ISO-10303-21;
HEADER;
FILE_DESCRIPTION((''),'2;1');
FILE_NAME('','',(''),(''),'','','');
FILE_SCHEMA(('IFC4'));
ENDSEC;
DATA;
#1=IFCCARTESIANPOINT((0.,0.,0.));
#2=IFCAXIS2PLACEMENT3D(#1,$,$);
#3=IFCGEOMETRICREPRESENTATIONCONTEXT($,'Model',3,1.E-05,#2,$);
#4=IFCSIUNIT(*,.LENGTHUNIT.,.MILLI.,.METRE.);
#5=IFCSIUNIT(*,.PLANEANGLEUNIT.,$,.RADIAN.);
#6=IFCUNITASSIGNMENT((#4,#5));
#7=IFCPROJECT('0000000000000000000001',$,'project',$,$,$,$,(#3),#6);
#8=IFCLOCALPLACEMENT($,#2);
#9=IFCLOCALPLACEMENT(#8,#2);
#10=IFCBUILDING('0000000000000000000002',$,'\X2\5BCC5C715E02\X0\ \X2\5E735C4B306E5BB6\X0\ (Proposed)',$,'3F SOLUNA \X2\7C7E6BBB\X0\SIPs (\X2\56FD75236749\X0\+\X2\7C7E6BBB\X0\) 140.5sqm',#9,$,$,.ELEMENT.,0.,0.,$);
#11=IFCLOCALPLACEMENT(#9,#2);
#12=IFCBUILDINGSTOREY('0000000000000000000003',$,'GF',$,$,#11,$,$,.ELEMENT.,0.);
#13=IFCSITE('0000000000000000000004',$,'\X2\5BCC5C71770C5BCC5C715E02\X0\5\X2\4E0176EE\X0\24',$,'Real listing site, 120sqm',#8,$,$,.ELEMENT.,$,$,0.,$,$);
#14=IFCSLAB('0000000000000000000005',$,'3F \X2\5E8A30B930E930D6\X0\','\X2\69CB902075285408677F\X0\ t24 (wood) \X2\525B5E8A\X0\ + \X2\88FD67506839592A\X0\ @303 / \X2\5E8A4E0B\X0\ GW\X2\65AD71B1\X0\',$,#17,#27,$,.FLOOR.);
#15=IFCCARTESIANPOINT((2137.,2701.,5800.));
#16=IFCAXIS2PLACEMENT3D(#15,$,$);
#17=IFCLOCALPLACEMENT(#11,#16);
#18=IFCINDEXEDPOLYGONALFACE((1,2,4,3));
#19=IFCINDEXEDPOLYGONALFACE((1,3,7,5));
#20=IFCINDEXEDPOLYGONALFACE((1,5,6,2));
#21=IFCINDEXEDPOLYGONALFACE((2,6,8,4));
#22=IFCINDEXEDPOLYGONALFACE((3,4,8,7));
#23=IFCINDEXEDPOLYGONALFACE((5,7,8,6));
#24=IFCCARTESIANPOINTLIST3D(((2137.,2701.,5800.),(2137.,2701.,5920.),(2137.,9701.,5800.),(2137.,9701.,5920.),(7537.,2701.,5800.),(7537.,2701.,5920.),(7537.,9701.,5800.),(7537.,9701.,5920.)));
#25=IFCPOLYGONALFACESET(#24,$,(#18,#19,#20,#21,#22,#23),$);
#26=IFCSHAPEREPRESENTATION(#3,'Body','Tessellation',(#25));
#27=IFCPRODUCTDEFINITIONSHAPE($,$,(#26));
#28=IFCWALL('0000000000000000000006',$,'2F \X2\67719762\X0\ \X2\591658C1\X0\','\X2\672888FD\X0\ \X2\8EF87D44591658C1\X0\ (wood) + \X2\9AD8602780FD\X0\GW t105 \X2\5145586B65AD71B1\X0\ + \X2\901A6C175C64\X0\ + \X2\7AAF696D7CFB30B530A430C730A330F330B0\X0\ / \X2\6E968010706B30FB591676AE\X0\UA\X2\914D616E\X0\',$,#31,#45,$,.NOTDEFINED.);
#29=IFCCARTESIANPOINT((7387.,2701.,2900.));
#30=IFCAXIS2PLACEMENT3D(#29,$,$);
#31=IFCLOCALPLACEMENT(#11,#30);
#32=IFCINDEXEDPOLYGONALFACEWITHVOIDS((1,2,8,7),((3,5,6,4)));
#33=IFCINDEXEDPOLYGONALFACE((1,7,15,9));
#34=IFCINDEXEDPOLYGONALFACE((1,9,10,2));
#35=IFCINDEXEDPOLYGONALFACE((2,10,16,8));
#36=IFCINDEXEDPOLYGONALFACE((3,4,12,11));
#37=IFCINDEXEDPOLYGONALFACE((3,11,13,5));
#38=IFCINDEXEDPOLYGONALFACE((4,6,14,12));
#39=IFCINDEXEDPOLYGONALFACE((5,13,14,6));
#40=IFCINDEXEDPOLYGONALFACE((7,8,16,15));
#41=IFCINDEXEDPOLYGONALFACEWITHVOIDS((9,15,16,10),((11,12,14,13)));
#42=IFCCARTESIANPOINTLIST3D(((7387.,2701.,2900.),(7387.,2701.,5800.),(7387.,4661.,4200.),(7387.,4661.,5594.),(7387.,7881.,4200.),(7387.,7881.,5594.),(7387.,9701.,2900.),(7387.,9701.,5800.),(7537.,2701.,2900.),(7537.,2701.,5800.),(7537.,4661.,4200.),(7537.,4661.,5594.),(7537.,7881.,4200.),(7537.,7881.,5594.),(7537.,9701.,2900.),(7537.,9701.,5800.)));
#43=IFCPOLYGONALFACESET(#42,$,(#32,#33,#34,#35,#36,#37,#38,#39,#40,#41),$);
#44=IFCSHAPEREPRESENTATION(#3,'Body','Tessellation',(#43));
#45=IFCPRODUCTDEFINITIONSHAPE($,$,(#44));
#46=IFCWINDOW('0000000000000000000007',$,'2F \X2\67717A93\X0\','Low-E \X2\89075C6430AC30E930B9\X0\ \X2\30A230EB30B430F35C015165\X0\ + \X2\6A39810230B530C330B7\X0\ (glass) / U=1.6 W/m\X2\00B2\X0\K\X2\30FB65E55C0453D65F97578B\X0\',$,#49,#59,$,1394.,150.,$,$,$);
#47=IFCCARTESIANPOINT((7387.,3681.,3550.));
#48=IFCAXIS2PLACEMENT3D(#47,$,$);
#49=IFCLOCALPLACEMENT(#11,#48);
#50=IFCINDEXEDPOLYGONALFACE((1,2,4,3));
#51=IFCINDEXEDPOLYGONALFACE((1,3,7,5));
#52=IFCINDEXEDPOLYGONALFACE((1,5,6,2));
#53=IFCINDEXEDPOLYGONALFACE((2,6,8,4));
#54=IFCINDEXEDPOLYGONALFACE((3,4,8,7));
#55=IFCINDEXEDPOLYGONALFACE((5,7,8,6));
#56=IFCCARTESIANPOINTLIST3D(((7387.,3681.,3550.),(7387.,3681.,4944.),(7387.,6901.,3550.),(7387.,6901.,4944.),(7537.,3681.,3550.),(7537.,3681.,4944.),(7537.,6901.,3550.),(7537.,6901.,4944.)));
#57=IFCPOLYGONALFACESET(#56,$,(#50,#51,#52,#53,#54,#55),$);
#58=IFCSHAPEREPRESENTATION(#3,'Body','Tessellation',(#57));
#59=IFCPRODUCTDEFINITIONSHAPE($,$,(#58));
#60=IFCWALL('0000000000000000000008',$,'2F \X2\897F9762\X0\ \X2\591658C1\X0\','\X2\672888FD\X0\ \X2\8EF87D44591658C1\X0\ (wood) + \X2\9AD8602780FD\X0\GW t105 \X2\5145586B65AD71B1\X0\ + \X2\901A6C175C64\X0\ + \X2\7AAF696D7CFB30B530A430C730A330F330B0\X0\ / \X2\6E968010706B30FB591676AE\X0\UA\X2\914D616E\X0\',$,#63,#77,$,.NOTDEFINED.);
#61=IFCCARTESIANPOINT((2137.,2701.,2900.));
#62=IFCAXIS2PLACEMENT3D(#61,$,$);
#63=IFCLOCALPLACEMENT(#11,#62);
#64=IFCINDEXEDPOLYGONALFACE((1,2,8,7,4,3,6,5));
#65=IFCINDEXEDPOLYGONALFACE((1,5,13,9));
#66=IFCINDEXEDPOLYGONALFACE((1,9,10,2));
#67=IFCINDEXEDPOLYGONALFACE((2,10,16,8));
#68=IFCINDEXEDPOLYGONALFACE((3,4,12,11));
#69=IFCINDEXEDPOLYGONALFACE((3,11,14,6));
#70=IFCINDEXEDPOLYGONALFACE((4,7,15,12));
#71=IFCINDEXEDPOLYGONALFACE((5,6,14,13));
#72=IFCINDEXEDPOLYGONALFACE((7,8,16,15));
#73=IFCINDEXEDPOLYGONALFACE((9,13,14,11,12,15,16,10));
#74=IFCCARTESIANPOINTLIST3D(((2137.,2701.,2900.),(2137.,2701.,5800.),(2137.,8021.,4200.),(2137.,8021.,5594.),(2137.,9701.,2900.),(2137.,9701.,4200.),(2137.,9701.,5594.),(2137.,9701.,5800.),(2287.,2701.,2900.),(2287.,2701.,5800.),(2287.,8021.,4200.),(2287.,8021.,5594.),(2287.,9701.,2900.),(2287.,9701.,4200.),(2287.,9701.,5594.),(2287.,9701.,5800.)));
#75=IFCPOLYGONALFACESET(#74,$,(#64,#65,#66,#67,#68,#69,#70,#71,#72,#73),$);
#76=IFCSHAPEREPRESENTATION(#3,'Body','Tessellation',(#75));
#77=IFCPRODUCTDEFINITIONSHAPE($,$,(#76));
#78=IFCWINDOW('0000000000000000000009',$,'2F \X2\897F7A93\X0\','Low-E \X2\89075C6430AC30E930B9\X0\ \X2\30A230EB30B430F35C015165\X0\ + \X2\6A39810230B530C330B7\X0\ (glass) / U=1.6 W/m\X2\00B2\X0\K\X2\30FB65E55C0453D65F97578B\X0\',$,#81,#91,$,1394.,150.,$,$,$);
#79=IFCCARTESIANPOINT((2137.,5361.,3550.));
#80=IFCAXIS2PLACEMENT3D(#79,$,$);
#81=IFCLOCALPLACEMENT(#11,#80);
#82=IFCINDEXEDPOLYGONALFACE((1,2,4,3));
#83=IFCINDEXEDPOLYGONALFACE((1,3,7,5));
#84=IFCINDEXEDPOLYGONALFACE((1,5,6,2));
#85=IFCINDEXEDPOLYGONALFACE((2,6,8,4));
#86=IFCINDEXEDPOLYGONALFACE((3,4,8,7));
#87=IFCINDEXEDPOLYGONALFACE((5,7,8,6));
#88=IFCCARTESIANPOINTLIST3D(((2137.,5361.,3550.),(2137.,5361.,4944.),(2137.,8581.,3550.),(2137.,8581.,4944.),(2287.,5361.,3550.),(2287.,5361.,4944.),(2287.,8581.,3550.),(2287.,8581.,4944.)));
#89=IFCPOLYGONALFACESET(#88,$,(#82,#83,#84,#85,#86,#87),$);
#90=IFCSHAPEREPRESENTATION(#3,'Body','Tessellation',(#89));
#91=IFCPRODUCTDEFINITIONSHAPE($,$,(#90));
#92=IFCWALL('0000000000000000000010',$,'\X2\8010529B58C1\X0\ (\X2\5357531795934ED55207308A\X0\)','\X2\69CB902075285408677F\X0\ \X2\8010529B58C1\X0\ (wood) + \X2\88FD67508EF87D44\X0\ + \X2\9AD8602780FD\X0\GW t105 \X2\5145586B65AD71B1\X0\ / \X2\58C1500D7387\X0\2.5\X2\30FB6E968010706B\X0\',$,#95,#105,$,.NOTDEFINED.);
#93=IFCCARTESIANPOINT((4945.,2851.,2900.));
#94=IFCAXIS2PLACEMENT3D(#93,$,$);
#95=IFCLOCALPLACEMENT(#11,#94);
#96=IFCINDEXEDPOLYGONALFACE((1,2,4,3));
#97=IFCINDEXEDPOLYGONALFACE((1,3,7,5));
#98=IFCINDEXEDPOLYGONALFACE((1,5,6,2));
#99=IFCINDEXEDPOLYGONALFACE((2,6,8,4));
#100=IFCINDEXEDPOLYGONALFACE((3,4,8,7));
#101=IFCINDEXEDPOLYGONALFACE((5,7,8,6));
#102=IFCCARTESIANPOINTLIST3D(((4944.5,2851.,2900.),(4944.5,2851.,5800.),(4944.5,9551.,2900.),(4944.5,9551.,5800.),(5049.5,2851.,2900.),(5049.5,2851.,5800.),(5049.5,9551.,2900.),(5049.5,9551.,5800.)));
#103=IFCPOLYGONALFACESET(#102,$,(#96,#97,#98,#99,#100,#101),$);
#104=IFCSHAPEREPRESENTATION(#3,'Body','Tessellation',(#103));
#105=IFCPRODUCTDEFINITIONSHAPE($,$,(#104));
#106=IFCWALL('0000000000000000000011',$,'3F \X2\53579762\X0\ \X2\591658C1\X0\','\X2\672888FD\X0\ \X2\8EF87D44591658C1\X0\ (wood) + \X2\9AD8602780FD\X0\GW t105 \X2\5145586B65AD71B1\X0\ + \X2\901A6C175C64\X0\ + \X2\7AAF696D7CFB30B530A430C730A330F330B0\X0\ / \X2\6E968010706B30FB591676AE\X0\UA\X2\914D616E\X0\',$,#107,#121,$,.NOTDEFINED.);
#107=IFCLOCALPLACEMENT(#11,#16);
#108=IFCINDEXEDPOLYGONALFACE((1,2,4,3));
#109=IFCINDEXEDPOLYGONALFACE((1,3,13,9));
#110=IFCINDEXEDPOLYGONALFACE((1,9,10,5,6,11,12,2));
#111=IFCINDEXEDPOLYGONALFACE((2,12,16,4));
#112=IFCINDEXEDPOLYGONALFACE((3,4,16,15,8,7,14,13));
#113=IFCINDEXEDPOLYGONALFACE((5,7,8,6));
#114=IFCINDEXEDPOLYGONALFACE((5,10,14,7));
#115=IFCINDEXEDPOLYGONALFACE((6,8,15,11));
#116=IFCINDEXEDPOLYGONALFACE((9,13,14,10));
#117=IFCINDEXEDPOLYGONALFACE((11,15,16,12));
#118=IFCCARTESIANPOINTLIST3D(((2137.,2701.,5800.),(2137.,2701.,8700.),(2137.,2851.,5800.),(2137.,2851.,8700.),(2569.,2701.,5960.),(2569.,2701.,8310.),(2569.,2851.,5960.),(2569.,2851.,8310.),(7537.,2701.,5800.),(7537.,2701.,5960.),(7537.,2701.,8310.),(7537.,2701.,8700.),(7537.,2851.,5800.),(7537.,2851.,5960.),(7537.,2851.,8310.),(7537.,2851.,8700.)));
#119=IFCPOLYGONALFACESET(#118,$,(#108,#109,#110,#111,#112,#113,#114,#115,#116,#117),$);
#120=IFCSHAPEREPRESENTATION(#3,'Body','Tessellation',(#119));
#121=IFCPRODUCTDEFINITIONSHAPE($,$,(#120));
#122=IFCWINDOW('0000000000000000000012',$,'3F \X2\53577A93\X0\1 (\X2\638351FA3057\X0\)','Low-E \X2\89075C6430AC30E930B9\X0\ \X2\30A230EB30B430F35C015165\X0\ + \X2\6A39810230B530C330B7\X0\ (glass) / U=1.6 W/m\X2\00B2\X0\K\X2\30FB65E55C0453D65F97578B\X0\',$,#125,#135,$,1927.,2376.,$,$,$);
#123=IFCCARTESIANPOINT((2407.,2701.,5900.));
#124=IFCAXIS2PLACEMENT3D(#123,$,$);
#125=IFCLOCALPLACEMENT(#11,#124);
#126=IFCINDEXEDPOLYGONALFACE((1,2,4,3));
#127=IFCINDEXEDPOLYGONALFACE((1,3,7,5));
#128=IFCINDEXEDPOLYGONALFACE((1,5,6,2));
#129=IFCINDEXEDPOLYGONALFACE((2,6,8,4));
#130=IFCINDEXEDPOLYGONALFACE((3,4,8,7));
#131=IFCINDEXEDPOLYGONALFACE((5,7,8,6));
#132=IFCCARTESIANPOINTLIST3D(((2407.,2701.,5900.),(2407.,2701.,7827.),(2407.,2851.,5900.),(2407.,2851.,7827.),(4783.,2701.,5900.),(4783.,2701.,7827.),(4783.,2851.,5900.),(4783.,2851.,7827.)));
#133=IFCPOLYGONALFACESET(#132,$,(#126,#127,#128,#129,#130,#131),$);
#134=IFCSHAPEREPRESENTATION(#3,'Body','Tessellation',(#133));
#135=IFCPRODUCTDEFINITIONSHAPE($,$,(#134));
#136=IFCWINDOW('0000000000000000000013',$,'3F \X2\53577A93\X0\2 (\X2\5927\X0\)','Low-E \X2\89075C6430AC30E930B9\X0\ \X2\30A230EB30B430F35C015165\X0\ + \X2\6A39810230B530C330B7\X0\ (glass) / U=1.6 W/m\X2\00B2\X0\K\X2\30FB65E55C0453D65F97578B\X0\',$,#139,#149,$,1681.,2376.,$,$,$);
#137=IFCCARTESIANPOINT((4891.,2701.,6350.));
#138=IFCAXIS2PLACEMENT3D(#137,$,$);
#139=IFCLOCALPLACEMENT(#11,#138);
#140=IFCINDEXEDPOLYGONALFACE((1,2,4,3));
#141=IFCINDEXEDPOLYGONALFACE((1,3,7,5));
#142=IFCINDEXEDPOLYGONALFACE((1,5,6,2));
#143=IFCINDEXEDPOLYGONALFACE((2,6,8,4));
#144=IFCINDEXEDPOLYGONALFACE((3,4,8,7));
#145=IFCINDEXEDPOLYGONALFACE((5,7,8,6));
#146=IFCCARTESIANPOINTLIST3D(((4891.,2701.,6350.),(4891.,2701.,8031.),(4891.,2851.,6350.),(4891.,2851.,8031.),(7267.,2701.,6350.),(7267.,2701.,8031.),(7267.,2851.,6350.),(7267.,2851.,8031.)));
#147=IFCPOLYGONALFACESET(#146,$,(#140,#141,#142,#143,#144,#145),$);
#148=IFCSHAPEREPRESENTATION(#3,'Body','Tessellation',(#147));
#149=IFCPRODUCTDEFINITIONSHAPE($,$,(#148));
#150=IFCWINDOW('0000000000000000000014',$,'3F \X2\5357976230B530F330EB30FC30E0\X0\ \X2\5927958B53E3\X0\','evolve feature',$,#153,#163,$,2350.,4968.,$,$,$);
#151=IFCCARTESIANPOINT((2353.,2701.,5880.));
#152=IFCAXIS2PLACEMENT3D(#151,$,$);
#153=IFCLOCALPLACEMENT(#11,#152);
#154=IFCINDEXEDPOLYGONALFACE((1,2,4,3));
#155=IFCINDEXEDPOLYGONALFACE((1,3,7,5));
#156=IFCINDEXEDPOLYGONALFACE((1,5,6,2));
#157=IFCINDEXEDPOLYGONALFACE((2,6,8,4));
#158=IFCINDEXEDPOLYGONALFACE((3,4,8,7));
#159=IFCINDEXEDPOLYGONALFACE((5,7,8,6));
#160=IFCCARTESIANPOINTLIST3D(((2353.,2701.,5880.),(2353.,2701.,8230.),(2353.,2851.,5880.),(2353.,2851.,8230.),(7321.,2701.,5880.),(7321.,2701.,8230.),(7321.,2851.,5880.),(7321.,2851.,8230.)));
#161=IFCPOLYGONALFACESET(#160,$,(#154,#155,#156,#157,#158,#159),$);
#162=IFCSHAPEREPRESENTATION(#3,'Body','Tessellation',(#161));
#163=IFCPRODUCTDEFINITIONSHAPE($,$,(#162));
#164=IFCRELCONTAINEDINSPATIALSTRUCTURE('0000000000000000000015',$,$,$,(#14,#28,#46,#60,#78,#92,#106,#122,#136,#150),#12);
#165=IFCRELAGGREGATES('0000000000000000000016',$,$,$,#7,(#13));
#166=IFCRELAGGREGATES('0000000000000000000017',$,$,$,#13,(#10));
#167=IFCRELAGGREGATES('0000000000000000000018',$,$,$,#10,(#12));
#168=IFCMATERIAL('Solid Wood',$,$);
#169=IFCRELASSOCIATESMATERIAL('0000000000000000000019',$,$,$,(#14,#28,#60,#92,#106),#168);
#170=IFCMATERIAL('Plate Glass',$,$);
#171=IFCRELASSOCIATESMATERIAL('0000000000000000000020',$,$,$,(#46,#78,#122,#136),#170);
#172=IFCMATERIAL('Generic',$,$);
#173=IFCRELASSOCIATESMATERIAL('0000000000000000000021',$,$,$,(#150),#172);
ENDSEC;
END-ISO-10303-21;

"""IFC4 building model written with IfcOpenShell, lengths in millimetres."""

from ifc_helpers import new_model, si_unit, frame, frame_2d, origin, place, context, project, spatial, rectangle, extrude, material, element, fill, save


model = new_model("IFC4")

# Units and contexts
model_context = context("Model", 3, precision=1e-05, world=origin())
ifc_project = project(units=[si_unit("LENGTHUNIT", "METRE", prefix="MILLI"), si_unit("PLANEANGLEUNIT", "RADIAN")], contexts=[model_context])

# Site, building, storey
site_placement = place(None, origin())
site = spatial("IfcSite", under=ifc_project, at=site_placement, Name="富山県富山市5丁目24", ObjectType="Real listing site, 120sqm", CompositionType="ELEMENT", RefElevation=0.0)
building_placement = place(site_placement, origin())
building = spatial("IfcBuilding", under=site, at=building_placement, Name="富山市 平屋の家 (Proposed)", ObjectType="3F SOLUNA 籾殻SIPs (国産杉+籾殻) 140.5sqm", CompositionType="ELEMENT", ElevationOfRefHeight=0.0, ElevationOfTerrain=0.0)
storey_placement = place(building_placement, origin())
storey = spatial("IfcBuildingStorey", under=building, at=storey_placement, Name="GF", CompositionType="ELEMENT", Elevation=0.0)

# Slab
ifc_material_1 = material(Name="Solid Wood")
slab_placement = place(storey_placement, frame((2137.0, 2701.0, 5800.0)))
element("IfcSlab", 1, at=slab_placement, inside=storey, material=ifc_material_1, Name="3F 床スラブ", Description="構造用合板 t24 (wood) 剛床 + 製材根太 @303 / 床下 GW断熱", PredefinedType="FLOOR", context=model_context, shape_type="SweptSolid", body=[
    extrude(rectangle(XDim=5400.0, YDim=7000.0, at=frame_2d((2700.0, 3500.0))), frame((2137.0, 2701.0, 5800.0)), (0.0, 0.0, 1.0), 120.0),
])

# Walls, openings, windows
wall_1_placement = place(storey_placement, frame((7387.0, 2701.0, 2900.0)))
wall_1 = element("IfcWall", 2, at=wall_1_placement, inside=storey, material=ifc_material_1, Name="2F 東面 外壁", Description="木製 軸組外壁 (wood) + 高性能GW t105 充填断熱 + 通気層 + 窯業系サイディング / 準耐火・外皮UA配慮", PredefinedType="NOTDEFINED", context=model_context, shape_type="SweptSolid", body=[
    extrude(rectangle(XDim=150.0, YDim=7000.0, at=frame_2d((75.0, 3500.0))), frame((7387.0, 2701.0, 2900.0)), (0.0, 0.0, 1.0), 2900.0),
])
opening_1_placement = place(storey_placement, frame((7387.0, 3681.0, 3550.0)))
opening_1 = element("IfcOpeningElement", 3, at=opening_1_placement, cuts=wall_1, PredefinedType="NOTDEFINED", context=model_context, shape_type="SweptSolid", body=[
    extrude(rectangle(XDim=150.0, YDim=3220.0, at=frame_2d((75.0, 1610.0))), frame((7387.0, 3681.0, 3550.0)), (0.0, 0.0, 1.0), 1394.0),
])
ifc_material_2 = material(Name="Plate Glass")
window_1_placement = place(storey_placement, frame((7387.0, 3681.0, 3550.0)))
window_1 = element("IfcWindow", 4, at=window_1_placement, inside=storey, material=ifc_material_2, Name="2F 東窓", Description="Low-E 複層ガラス アルゴン封入 + 樹脂サッシ (glass) / U=1.6 W/m²K・日射取得型", OverallHeight=1394.0, OverallWidth=150.0, context=model_context, shape_type="SweptSolid", body=[
    extrude(rectangle(XDim=150.0, YDim=3220.0, at=frame_2d((75.0, 1610.0))), frame((7387.0, 3681.0, 3550.0)), (0.0, 0.0, 1.0), 1394.0),
])
fill(opening_1, window_1)
wall_2_placement = place(storey_placement, frame((2137.0, 2701.0, 2900.0)))
wall_2 = element("IfcWall", 5, at=wall_2_placement, inside=storey, material=ifc_material_1, Name="2F 西面 外壁", Description="木製 軸組外壁 (wood) + 高性能GW t105 充填断熱 + 通気層 + 窯業系サイディング / 準耐火・外皮UA配慮", PredefinedType="NOTDEFINED", context=model_context, shape_type="SweptSolid", body=[
    extrude(rectangle(XDim=150.0, YDim=7000.0, at=frame_2d((75.0, 3500.0))), frame((2137.0, 2701.0, 2900.0)), (0.0, 0.0, 1.0), 2900.0),
])
opening_2_placement = place(storey_placement, frame((2137.0, 5361.0, 3550.0)))
opening_2 = element("IfcOpeningElement", 6, at=opening_2_placement, cuts=wall_2, PredefinedType="NOTDEFINED", context=model_context, shape_type="SweptSolid", body=[
    extrude(rectangle(XDim=150.0, YDim=3220.0, at=frame_2d((75.0, 1610.0))), frame((2137.0, 5361.0, 3550.0)), (0.0, 0.0, 1.0), 1394.0),
])
window_2_placement = place(storey_placement, frame((2137.0, 5361.0, 3550.0)))
window_2 = element("IfcWindow", 7, at=window_2_placement, inside=storey, material=ifc_material_2, Name="2F 西窓", Description="Low-E 複層ガラス アルゴン封入 + 樹脂サッシ (glass) / U=1.6 W/m²K・日射取得型", OverallHeight=1394.0, OverallWidth=150.0, context=model_context, shape_type="SweptSolid", body=[
    extrude(rectangle(XDim=150.0, YDim=3220.0, at=frame_2d((75.0, 1610.0))), frame((2137.0, 5361.0, 3550.0)), (0.0, 0.0, 1.0), 1394.0),
])
fill(opening_2, window_2)

# Wall
wall_3_placement = place(storey_placement, frame((4945.0, 2851.0, 2900.0)))
element("IfcWall", 8, at=wall_3_placement, inside=storey, material=ifc_material_1, Name="耐力壁 (南北間仕切り)", Description="構造用合板 耐力壁 (wood) + 製材軸組 + 高性能GW t105 充填断熱 / 壁倍率2.5・準耐火", PredefinedType="NOTDEFINED", context=model_context, shape_type="SweptSolid", body=[
    extrude(rectangle(XDim=105.0, YDim=6700.0, at=frame_2d((52.0, 3350.0))), frame((4945.0, 2851.0, 2900.0)), (0.0, 0.0, 1.0), 2900.0),
])

# Wall, openings, windows
wall_4_placement = place(storey_placement, frame((2137.0, 2701.0, 5800.0)))
wall_4 = element("IfcWall", 9, at=wall_4_placement, inside=storey, material=ifc_material_1, Name="3F 南面 外壁", Description="木製 軸組外壁 (wood) + 高性能GW t105 充填断熱 + 通気層 + 窯業系サイディング / 準耐火・外皮UA配慮", PredefinedType="NOTDEFINED", context=model_context, shape_type="SweptSolid", body=[
    extrude(rectangle(XDim=5400.0, YDim=150.0, at=frame_2d((2700.0, 75.0))), frame((2137.0, 2701.0, 5800.0)), (0.0, 0.0, 1.0), 2900.0),
])
opening_3_placement = place(storey_placement, frame((2407.0, 2701.0, 5900.0)))
opening_3 = element("IfcOpeningElement", 10, at=opening_3_placement, cuts=wall_4, PredefinedType="NOTDEFINED", context=model_context, shape_type="SweptSolid", body=[
    extrude(rectangle(XDim=2376.0, YDim=150.0, at=frame_2d((1188.0, 75.0))), frame((2407.0, 2701.0, 5900.0)), (0.0, 0.0, 1.0), 1927.0),
])
opening_4_placement = place(storey_placement, frame((4891.0, 2701.0, 6350.0)))
opening_4 = element("IfcOpeningElement", 11, at=opening_4_placement, cuts=wall_4, PredefinedType="NOTDEFINED", context=model_context, shape_type="SweptSolid", body=[
    extrude(rectangle(XDim=2376.0, YDim=150.0, at=frame_2d((1188.0, 75.0))), frame((4891.0, 2701.0, 6350.0)), (0.0, 0.0, 1.0), 1681.0),
])
opening_5_placement = place(storey_placement, frame((2353.0, 2701.0, 5880.0)))
opening_5 = element("IfcOpeningElement", 12, at=opening_5_placement, cuts=wall_4, PredefinedType="NOTDEFINED", context=model_context, shape_type="SweptSolid", body=[
    extrude(rectangle(XDim=4968.0, YDim=150.0, at=frame_2d((2484.0, 75.0))), frame((2353.0, 2701.0, 5880.0)), (0.0, 0.0, 1.0), 2350.0),
])
window_3_placement = place(storey_placement, frame((2407.0, 2701.0, 5900.0)))
window_3 = element("IfcWindow", 13, at=window_3_placement, inside=storey, material=ifc_material_2, Name="3F 南窓1 (掃出し)", Description="Low-E 複層ガラス アルゴン封入 + 樹脂サッシ (glass) / U=1.6 W/m²K・日射取得型", OverallHeight=1927.0, OverallWidth=2376.0, context=model_context, shape_type="SweptSolid", body=[
    extrude(rectangle(XDim=2376.0, YDim=150.0, at=frame_2d((1188.0, 75.0))), frame((2407.0, 2701.0, 5900.0)), (0.0, 0.0, 1.0), 1927.0),
])
fill(opening_3, window_3)
window_4_placement = place(storey_placement, frame((4891.0, 2701.0, 6350.0)))
window_4 = element("IfcWindow", 14, at=window_4_placement, inside=storey, material=ifc_material_2, Name="3F 南窓2 (大)", Description="Low-E 複層ガラス アルゴン封入 + 樹脂サッシ (glass) / U=1.6 W/m²K・日射取得型", OverallHeight=1681.0, OverallWidth=2376.0, context=model_context, shape_type="SweptSolid", body=[
    extrude(rectangle(XDim=2376.0, YDim=150.0, at=frame_2d((1188.0, 75.0))), frame((4891.0, 2701.0, 6350.0)), (0.0, 0.0, 1.0), 1681.0),
])
fill(opening_4, window_4)
ifc_material_3 = material(Name="Generic")
window_5_placement = place(storey_placement, frame((2353.0, 2701.0, 5880.0)))
window_5 = element("IfcWindow", 15, at=window_5_placement, inside=storey, material=ifc_material_3, Name="3F 南面サンルーム 大開口", Description="evolve feature", OverallHeight=2350.0, OverallWidth=4968.0, context=model_context, shape_type="SweptSolid", body=[
    extrude(rectangle(XDim=4968.0, YDim=150.0, at=frame_2d((2484.0, 75.0))), frame((2353.0, 2701.0, 5880.0)), (0.0, 0.0, 1.0), 2350.0),
])
fill(opening_5, window_5)

save(model, "model.ifc")
